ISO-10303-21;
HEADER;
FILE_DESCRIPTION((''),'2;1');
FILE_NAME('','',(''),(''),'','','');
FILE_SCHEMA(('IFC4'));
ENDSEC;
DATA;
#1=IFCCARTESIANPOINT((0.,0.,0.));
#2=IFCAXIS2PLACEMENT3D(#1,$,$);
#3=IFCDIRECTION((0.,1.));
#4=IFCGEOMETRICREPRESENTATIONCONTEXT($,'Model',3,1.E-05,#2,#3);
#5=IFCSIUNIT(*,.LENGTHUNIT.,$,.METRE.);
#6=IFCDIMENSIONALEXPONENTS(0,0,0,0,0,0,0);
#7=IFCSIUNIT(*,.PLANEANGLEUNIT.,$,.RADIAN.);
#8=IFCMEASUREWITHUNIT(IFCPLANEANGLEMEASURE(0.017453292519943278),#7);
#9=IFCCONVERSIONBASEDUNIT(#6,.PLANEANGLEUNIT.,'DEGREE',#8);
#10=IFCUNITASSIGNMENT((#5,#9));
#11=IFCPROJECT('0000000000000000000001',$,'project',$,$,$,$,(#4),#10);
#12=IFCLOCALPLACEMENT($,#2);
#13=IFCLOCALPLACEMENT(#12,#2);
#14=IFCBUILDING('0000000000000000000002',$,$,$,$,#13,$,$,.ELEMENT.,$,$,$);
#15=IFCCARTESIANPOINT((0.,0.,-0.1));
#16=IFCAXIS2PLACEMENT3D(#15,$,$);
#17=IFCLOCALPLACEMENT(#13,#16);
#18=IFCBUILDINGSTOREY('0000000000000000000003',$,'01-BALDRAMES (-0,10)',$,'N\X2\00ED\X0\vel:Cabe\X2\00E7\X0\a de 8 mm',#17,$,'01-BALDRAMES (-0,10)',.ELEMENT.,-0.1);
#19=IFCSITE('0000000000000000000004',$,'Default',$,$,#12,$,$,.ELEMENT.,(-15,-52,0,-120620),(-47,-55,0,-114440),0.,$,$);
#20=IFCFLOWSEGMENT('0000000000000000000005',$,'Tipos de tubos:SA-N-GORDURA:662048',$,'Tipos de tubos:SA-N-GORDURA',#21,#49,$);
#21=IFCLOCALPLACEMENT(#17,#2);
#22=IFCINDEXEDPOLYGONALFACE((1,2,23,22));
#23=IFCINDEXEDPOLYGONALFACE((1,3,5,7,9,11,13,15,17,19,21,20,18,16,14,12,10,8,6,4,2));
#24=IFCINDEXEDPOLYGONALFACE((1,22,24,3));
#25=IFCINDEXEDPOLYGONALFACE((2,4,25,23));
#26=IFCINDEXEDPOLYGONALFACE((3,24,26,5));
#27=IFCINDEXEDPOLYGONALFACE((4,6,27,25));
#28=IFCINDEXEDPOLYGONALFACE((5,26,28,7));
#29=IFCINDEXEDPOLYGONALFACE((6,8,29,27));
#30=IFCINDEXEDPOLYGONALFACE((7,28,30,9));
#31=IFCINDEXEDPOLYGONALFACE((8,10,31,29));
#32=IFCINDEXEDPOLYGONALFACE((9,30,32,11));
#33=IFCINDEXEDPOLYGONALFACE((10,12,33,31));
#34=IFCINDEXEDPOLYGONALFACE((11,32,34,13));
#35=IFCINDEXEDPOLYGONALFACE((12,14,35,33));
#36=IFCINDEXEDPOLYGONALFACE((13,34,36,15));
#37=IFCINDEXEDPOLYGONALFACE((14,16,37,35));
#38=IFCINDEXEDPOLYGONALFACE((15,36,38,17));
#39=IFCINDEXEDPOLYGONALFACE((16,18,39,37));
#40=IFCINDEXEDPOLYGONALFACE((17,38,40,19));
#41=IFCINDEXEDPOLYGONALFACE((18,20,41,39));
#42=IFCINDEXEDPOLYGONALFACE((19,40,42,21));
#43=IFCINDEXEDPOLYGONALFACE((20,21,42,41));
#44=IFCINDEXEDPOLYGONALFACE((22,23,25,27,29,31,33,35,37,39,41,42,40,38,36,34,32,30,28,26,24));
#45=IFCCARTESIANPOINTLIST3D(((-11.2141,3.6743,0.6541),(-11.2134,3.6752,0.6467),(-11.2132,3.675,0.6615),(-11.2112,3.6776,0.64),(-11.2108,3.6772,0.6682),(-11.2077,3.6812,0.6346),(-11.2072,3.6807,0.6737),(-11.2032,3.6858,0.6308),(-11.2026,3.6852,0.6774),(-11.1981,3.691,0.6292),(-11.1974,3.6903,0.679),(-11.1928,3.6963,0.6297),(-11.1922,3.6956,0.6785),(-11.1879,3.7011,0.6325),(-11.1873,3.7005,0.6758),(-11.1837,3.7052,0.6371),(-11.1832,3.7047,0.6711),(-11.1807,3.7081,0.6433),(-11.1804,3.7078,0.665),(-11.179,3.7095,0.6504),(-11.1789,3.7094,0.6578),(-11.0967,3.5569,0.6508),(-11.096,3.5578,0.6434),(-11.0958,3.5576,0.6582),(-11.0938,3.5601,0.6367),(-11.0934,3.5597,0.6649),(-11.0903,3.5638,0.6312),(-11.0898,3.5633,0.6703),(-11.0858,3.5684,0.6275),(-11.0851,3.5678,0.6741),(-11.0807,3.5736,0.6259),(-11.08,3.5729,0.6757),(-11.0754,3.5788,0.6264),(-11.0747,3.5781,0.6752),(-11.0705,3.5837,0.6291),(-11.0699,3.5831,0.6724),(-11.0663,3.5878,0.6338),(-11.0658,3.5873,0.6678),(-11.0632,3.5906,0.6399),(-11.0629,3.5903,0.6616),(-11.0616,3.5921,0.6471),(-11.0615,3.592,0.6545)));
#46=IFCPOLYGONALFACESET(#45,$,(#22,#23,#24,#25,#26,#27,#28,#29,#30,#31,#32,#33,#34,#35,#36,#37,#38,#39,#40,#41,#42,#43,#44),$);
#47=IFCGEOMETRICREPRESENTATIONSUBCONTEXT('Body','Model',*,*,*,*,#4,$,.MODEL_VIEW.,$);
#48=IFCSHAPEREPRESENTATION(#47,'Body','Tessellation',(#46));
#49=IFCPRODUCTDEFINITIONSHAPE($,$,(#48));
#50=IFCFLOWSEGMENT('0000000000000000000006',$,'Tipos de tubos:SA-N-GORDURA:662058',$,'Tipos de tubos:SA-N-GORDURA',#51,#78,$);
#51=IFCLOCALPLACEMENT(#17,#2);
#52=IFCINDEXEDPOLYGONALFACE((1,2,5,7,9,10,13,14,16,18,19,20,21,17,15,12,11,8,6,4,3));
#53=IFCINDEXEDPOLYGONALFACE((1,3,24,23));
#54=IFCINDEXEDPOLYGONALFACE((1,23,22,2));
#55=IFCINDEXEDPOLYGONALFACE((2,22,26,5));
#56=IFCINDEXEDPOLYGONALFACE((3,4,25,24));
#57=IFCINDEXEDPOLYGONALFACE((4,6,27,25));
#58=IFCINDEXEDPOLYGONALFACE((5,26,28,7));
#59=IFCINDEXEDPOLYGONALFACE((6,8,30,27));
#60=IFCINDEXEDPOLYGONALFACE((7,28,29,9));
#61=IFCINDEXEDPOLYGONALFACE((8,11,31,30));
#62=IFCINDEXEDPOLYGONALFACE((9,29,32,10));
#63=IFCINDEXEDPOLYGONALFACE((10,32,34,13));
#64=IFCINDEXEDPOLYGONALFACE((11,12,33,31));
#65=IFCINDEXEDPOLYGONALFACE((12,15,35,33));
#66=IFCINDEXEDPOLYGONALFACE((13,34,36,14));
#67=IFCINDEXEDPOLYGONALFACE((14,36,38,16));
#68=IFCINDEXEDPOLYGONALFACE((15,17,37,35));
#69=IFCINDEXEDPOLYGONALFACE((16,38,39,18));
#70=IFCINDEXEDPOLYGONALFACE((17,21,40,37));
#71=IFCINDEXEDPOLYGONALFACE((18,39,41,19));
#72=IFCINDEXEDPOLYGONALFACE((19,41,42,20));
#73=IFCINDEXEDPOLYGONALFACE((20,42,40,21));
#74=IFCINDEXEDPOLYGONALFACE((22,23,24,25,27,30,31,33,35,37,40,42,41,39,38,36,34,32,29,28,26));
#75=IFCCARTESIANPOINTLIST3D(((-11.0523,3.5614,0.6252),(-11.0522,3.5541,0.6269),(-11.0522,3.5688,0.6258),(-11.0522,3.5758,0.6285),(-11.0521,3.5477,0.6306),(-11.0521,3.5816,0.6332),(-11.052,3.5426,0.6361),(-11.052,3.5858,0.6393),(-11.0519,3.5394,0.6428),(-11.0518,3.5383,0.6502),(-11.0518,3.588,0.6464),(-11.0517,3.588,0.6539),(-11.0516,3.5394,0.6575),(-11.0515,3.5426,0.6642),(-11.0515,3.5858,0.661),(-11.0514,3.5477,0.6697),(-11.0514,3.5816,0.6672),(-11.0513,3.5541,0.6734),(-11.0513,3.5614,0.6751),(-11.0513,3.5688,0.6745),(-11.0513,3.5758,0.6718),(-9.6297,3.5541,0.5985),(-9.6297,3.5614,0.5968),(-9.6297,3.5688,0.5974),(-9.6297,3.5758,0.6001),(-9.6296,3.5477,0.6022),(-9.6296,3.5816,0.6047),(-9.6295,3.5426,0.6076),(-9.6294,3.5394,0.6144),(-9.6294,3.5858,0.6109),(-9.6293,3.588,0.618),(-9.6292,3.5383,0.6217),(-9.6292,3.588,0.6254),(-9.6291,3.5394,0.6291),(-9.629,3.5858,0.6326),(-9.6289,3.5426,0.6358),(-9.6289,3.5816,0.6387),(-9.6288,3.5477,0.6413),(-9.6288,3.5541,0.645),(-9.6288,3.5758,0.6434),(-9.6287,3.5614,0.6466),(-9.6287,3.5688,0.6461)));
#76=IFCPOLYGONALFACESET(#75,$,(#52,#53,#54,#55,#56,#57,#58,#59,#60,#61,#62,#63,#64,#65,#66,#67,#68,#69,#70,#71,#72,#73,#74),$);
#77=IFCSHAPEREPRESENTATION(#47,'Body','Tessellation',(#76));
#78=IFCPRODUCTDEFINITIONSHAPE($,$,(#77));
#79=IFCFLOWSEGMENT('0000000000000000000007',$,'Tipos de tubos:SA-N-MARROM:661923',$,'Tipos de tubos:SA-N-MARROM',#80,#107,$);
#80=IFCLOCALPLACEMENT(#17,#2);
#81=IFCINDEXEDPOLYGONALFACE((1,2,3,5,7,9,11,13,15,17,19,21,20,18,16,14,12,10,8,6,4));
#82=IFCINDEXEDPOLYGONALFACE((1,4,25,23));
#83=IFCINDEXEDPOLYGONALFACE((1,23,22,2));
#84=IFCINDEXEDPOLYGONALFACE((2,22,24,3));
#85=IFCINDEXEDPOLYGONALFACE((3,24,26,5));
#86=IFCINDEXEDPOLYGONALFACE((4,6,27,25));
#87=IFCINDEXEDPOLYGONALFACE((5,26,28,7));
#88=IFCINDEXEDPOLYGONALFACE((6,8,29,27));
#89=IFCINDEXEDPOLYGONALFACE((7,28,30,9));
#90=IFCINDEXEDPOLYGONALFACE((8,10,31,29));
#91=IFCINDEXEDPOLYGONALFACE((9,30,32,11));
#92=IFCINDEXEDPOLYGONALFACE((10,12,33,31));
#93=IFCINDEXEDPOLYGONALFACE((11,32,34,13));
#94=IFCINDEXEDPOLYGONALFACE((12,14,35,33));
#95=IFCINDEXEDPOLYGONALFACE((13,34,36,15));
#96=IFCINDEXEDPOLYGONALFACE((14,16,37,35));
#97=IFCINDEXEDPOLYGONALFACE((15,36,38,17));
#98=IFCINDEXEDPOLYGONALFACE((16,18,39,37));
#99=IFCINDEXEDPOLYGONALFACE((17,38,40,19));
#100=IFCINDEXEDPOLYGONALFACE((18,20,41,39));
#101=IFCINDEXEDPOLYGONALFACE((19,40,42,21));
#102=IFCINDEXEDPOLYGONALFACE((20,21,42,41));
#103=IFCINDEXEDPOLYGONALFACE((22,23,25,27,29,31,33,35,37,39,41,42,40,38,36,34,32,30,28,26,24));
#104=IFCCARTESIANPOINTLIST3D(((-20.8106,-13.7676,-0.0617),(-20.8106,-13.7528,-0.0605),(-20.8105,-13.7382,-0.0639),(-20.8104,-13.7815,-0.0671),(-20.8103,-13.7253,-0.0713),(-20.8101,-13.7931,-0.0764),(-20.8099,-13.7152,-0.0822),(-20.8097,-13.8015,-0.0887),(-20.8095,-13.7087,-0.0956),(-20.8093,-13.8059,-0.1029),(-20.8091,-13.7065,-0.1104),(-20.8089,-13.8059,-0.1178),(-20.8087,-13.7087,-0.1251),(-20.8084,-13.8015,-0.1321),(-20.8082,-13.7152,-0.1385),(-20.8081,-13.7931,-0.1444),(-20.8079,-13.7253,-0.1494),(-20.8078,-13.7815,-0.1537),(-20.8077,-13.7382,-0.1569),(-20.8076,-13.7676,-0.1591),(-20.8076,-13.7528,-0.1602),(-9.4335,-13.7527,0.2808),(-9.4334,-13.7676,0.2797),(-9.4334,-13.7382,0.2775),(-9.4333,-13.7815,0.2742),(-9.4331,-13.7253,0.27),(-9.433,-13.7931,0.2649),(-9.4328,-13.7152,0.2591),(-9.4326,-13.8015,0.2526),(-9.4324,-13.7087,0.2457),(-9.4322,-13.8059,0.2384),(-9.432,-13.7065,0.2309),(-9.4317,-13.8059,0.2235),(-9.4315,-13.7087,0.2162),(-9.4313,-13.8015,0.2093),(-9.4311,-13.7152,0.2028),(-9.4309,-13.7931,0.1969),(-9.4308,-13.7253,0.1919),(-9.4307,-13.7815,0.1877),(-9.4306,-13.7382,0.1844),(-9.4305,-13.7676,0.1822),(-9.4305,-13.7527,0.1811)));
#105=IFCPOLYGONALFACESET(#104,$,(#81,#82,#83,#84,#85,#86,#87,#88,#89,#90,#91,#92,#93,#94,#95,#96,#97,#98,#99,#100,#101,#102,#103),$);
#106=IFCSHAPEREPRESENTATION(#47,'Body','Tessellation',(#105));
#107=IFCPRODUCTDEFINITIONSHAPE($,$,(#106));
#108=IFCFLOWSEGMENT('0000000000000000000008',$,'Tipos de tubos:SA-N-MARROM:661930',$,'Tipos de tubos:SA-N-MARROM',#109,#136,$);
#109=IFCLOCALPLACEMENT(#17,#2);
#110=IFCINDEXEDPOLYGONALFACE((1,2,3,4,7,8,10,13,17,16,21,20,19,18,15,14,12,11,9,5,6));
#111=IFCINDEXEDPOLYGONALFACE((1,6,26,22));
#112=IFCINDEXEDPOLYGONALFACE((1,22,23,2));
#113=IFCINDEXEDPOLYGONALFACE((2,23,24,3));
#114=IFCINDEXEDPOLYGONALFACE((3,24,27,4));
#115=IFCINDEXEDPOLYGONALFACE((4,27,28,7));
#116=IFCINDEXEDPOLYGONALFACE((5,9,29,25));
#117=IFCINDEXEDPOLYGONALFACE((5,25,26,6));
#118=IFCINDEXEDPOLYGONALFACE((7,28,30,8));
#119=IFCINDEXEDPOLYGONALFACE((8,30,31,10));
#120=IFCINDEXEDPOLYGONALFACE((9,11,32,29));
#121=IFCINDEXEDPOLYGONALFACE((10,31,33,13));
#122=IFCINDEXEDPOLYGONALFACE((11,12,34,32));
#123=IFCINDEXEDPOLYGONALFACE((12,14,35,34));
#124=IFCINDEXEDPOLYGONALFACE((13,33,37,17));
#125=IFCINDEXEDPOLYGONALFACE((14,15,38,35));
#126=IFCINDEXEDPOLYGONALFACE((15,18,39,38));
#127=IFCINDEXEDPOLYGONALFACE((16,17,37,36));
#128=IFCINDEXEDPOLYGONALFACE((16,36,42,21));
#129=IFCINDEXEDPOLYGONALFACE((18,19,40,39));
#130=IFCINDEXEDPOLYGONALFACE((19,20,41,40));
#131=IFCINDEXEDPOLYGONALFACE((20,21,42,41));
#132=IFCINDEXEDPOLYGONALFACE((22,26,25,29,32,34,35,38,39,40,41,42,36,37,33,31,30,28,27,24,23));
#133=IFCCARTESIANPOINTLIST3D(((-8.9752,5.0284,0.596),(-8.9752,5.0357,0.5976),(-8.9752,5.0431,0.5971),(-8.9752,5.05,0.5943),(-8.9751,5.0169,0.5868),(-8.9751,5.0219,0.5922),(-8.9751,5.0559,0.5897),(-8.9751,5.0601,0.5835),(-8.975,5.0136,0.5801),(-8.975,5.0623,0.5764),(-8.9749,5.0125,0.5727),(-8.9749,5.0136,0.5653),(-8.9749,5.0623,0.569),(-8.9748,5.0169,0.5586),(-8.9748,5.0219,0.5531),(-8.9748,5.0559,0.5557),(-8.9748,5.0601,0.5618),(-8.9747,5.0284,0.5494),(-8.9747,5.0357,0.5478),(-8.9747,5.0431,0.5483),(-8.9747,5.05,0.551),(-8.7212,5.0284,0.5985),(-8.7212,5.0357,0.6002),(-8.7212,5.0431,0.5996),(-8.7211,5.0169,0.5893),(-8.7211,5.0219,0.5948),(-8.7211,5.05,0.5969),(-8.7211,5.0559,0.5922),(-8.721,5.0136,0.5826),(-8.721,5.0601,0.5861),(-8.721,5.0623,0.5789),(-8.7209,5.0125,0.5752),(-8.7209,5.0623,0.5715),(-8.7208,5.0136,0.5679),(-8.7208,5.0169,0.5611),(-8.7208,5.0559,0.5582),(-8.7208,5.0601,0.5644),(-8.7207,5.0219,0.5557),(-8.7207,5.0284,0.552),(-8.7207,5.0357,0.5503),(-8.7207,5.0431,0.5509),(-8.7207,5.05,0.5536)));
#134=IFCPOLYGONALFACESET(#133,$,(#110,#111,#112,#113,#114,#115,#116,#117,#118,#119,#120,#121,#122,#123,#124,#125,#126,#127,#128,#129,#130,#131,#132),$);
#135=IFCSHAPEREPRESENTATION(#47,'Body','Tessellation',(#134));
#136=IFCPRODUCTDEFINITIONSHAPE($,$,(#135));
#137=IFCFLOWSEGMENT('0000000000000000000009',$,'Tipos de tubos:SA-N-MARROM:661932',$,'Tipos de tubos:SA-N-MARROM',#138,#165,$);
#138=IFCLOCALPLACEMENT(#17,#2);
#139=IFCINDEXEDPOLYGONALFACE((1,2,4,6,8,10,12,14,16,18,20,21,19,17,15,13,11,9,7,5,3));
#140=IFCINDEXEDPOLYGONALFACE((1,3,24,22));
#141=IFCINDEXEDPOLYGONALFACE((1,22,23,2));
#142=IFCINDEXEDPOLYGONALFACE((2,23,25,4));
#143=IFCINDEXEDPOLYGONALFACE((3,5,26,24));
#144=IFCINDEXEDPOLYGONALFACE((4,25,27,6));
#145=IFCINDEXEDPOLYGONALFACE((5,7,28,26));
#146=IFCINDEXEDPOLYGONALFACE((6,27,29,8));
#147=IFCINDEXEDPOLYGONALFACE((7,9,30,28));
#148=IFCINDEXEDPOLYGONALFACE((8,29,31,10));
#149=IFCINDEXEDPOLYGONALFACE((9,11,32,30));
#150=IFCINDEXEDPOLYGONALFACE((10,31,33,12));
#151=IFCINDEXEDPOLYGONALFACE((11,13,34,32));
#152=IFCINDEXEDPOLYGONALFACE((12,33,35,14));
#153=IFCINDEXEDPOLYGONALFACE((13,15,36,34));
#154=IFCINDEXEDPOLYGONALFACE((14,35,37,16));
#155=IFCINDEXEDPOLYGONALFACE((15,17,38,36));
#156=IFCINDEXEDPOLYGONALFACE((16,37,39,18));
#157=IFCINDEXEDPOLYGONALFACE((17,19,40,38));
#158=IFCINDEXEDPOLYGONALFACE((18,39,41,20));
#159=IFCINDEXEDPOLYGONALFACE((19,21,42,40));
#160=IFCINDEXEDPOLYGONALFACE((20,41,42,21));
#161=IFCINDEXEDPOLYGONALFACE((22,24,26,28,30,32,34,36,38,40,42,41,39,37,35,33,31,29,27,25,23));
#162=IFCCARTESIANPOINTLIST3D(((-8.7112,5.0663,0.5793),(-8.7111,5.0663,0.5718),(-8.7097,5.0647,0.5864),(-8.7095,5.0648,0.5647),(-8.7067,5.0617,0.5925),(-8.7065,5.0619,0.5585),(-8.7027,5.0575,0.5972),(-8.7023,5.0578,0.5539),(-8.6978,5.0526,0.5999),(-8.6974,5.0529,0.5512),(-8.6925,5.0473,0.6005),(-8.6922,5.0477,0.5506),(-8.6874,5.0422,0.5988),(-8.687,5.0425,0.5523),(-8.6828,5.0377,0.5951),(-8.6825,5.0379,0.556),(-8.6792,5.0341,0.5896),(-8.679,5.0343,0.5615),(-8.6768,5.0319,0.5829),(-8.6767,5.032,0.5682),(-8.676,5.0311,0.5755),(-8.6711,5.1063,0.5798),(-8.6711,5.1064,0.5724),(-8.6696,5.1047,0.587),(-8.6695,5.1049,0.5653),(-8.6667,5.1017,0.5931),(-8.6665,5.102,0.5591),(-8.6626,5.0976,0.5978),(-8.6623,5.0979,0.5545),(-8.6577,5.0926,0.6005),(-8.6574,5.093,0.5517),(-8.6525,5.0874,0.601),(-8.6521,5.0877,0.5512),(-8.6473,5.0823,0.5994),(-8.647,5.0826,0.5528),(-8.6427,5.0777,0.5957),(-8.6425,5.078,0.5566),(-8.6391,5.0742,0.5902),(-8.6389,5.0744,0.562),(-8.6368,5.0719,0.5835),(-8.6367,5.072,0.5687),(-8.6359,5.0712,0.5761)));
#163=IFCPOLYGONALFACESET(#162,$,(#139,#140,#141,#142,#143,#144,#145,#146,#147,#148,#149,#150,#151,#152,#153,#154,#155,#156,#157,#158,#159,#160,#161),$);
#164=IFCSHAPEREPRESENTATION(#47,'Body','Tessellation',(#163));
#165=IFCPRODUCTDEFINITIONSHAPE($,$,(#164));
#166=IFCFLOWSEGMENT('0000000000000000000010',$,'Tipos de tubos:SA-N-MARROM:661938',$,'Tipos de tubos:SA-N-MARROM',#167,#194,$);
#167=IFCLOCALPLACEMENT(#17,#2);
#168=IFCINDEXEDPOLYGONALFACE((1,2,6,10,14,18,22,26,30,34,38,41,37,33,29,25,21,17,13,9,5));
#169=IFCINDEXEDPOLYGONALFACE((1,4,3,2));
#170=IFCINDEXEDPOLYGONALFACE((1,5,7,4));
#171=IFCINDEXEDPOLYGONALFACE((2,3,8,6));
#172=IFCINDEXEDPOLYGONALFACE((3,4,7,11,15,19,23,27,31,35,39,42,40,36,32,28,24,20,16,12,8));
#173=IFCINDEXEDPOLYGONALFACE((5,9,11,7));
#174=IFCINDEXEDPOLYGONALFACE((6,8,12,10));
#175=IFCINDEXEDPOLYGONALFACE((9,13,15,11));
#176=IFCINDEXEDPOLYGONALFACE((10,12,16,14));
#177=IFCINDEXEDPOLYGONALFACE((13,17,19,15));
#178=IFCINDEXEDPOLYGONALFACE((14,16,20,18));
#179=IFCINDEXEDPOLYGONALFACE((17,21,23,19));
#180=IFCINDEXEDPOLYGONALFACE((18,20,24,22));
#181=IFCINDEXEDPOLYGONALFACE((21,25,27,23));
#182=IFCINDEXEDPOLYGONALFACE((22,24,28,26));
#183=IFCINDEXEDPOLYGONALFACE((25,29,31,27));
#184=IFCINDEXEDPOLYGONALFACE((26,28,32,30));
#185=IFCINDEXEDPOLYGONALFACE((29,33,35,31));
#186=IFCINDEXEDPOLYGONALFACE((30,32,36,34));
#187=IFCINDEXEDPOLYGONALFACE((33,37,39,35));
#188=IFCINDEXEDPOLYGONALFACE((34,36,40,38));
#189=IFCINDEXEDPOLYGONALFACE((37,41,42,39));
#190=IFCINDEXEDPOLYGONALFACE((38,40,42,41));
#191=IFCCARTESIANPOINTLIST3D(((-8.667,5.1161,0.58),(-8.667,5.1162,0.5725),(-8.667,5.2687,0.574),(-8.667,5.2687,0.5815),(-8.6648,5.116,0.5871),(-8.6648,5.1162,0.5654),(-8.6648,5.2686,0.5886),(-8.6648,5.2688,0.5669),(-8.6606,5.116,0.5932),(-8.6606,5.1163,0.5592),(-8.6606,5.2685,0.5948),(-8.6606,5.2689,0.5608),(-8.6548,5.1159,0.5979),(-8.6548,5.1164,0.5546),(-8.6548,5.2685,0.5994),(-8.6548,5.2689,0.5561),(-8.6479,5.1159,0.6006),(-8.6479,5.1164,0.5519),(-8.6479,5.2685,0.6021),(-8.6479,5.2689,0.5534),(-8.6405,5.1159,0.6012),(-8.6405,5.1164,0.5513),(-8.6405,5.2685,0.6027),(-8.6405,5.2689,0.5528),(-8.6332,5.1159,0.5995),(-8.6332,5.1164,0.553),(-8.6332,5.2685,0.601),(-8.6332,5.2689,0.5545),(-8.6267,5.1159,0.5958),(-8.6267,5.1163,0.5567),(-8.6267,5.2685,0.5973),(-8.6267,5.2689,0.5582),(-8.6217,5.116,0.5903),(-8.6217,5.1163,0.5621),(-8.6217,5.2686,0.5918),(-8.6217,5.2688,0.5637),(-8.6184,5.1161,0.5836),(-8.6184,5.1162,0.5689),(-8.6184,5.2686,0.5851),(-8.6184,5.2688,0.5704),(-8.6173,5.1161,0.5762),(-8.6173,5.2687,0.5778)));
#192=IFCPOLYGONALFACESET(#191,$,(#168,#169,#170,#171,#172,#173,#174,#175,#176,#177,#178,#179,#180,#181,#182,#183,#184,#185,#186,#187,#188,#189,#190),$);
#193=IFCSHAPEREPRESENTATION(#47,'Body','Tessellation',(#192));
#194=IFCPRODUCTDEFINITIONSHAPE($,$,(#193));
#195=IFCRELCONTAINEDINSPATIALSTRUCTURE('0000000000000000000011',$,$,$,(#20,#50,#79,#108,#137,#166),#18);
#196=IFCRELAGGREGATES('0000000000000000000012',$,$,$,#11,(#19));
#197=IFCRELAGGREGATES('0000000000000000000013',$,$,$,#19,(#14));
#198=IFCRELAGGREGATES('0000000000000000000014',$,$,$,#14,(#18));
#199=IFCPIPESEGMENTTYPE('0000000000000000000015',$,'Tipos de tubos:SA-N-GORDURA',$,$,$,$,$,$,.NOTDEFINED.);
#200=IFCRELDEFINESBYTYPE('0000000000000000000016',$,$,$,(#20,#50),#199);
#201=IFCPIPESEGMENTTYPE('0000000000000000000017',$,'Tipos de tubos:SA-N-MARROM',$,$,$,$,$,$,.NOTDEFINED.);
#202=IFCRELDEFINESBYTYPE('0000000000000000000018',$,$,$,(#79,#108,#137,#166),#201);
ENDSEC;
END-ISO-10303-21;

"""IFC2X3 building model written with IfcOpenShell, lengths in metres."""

from ifc_helpers import new_model, entity, si_unit, converted_unit, direction, frame, frame_2d, origin, origin_2d_with_axis, place, context, subcontext, project, spatial, circle, extrude, type_object, element, save


model = new_model("IFC2X3")

# Units and contexts
model_context = context("Model", 3, precision=1e-05, world=origin(), true_north=direction((0.0, 1.0)))
body_context = subcontext(model_context, "Body", "Model", "MODEL_VIEW")
ifc_project = project(units=[si_unit("LENGTHUNIT", "METRE"), converted_unit("PLANEANGLEUNIT", "DEGREE", entity("IfcPlaneAngleMeasure", 0.017453292519943278), si_unit("PLANEANGLEUNIT", "RADIAN"), dimensions=[0, 0, 0, 0, 0, 0, 0])], contexts=[model_context])

# Site, building, storey
site_placement = place(None, origin())
site = spatial("IfcSite", under=ifc_project, at=site_placement, Name="Default", CompositionType="ELEMENT", RefLatitude=(-15, -52, 0, -120620), RefLongitude=(-47, -55, 0, -114440), RefElevation=0.0)
building_placement = place(site_placement, origin())
building = spatial("IfcBuilding", under=site, at=building_placement, CompositionType="ELEMENT")
storey_placement = place(building_placement, frame((0.0, 0.0, -0.1)))
storey = spatial("IfcBuildingStorey", under=building, at=storey_placement, Name="01-BALDRAMES (-0,10)", ObjectType="Nível:Cabeça de 8 mm", LongName="01-BALDRAMES (-0,10)", CompositionType="ELEMENT", Elevation=-0.1)

# Flow segments
pipe_segment_type_1 = type_object("IfcPipeSegmentType", Name="Tipos de tubos:SA-N-GORDURA", PredefinedType="NOTDEFINED")
flow_segment_1_placement = place(storey_placement, origin())
element("IfcFlowSegment", 1, at=flow_segment_1_placement, inside=storey, type_object=pipe_segment_type_1, Name="Tipos de tubos:SA-N-GORDURA:662048", ObjectType="Tipos de tubos:SA-N-GORDURA", context=body_context, shape_type="SweptSolid", body=[
    extrude(circle(Radius=0.025, at=origin_2d_with_axis()), frame((-11.1964, 3.692, 0.6541), z_axis=(0.706966, -0.706965, -0.019996), x_axis=(-0.707106, -0.707107, 0.0)), (0.0, 0.0, 1.0), 0.1661),
])
flow_segment_2_placement = place(storey_placement, origin())
element("IfcFlowSegment", 2, at=flow_segment_2_placement, inside=storey, type_object=pipe_segment_type_1, Name="Tipos de tubos:SA-N-GORDURA:662058", ObjectType="Tipos de tubos:SA-N-GORDURA", context=body_context, shape_type="SweptSolid", body=[
    extrude(circle(Radius=0.025, at=frame_2d((0.0, 0.0), x_axis=(1.0, 0.0))), frame((-9.6292, 3.5633, 0.6217), z_axis=(-0.9998, -0.000001, 0.019982), x_axis=(0.000001, -1.0, 0.0)), (0.0, 0.0, 1.0), 1.4228),
])
pipe_segment_type_2 = type_object("IfcPipeSegmentType", Name="Tipos de tubos:SA-N-MARROM", PredefinedType="NOTDEFINED")
flow_segment_3_placement = place(storey_placement, origin())
element("IfcFlowSegment", 3, at=flow_segment_3_placement, inside=storey, type_object=pipe_segment_type_2, Name="Tipos de tubos:SA-N-MARROM:661923", ObjectType="Tipos de tubos:SA-N-MARROM", context=body_context, shape_type="SweptSolid", body=[
    extrude(circle(Radius=0.05, at=frame_2d((0.0, 0.0), x_axis=(1.0, 0.0))), frame((-20.8091, -13.7565, -0.1104), z_axis=(0.99955, 0.000001, 0.029987), x_axis=(-0.000001, 1.0, 0.0)), (0.0, 0.0, 1.0), 11.3823),
])
flow_segment_4_placement = place(storey_placement, origin())
element("IfcFlowSegment", 4, at=flow_segment_4_placement, inside=storey, type_object=pipe_segment_type_2, Name="Tipos de tubos:SA-N-MARROM:661930", ObjectType="Tipos de tubos:SA-N-MARROM", context=body_context, shape_type="SweptSolid", body=[
    extrude(circle(Radius=0.025, at=frame_2d((0.0, 0.0), x_axis=(1.0, 0.0))), frame((-8.9749, 5.0375, 0.5727), z_axis=(0.99995, 0.000001, 0.01), x_axis=(0.000001, -1.0, 0.0)), (0.0, 0.0, 1.0), 0.254),
])
flow_segment_5_placement = place(storey_placement, origin())
element("IfcFlowSegment", 5, at=flow_segment_5_placement, inside=storey, type_object=pipe_segment_type_2, Name="Tipos de tubos:SA-N-MARROM:661932", ObjectType="Tipos de tubos:SA-N-MARROM", context=body_context, shape_type="SweptSolid", body=[
    extrude(circle(Radius=0.025, at=origin_2d_with_axis()), frame((-8.6937, 5.0488, 0.5755), z_axis=(0.707071, 0.707072, 0.01), x_axis=(0.707107, -0.707106, 0.0)), (0.0, 0.0, 1.0), 0.0566),
])
flow_segment_6_placement = place(storey_placement, origin())
element("IfcFlowSegment", 6, at=flow_segment_6_placement, inside=storey, type_object=pipe_segment_type_2, Name="Tipos de tubos:SA-N-MARROM:661938", ObjectType="Tipos de tubos:SA-N-MARROM", context=body_context, shape_type="SweptSolid", body=[
    extrude(circle(Radius=0.025, at=frame_2d((0.0, 0.0), x_axis=(1.0, 0.0))), frame((-8.6423, 5.1161, 0.5762), z_axis=(-0.000001, 0.99995, 0.01), x_axis=(1.0, 0.000001, 0.0)), (0.0, 0.0, 1.0), 0.1526),
])

save(model, "model.ifc")
